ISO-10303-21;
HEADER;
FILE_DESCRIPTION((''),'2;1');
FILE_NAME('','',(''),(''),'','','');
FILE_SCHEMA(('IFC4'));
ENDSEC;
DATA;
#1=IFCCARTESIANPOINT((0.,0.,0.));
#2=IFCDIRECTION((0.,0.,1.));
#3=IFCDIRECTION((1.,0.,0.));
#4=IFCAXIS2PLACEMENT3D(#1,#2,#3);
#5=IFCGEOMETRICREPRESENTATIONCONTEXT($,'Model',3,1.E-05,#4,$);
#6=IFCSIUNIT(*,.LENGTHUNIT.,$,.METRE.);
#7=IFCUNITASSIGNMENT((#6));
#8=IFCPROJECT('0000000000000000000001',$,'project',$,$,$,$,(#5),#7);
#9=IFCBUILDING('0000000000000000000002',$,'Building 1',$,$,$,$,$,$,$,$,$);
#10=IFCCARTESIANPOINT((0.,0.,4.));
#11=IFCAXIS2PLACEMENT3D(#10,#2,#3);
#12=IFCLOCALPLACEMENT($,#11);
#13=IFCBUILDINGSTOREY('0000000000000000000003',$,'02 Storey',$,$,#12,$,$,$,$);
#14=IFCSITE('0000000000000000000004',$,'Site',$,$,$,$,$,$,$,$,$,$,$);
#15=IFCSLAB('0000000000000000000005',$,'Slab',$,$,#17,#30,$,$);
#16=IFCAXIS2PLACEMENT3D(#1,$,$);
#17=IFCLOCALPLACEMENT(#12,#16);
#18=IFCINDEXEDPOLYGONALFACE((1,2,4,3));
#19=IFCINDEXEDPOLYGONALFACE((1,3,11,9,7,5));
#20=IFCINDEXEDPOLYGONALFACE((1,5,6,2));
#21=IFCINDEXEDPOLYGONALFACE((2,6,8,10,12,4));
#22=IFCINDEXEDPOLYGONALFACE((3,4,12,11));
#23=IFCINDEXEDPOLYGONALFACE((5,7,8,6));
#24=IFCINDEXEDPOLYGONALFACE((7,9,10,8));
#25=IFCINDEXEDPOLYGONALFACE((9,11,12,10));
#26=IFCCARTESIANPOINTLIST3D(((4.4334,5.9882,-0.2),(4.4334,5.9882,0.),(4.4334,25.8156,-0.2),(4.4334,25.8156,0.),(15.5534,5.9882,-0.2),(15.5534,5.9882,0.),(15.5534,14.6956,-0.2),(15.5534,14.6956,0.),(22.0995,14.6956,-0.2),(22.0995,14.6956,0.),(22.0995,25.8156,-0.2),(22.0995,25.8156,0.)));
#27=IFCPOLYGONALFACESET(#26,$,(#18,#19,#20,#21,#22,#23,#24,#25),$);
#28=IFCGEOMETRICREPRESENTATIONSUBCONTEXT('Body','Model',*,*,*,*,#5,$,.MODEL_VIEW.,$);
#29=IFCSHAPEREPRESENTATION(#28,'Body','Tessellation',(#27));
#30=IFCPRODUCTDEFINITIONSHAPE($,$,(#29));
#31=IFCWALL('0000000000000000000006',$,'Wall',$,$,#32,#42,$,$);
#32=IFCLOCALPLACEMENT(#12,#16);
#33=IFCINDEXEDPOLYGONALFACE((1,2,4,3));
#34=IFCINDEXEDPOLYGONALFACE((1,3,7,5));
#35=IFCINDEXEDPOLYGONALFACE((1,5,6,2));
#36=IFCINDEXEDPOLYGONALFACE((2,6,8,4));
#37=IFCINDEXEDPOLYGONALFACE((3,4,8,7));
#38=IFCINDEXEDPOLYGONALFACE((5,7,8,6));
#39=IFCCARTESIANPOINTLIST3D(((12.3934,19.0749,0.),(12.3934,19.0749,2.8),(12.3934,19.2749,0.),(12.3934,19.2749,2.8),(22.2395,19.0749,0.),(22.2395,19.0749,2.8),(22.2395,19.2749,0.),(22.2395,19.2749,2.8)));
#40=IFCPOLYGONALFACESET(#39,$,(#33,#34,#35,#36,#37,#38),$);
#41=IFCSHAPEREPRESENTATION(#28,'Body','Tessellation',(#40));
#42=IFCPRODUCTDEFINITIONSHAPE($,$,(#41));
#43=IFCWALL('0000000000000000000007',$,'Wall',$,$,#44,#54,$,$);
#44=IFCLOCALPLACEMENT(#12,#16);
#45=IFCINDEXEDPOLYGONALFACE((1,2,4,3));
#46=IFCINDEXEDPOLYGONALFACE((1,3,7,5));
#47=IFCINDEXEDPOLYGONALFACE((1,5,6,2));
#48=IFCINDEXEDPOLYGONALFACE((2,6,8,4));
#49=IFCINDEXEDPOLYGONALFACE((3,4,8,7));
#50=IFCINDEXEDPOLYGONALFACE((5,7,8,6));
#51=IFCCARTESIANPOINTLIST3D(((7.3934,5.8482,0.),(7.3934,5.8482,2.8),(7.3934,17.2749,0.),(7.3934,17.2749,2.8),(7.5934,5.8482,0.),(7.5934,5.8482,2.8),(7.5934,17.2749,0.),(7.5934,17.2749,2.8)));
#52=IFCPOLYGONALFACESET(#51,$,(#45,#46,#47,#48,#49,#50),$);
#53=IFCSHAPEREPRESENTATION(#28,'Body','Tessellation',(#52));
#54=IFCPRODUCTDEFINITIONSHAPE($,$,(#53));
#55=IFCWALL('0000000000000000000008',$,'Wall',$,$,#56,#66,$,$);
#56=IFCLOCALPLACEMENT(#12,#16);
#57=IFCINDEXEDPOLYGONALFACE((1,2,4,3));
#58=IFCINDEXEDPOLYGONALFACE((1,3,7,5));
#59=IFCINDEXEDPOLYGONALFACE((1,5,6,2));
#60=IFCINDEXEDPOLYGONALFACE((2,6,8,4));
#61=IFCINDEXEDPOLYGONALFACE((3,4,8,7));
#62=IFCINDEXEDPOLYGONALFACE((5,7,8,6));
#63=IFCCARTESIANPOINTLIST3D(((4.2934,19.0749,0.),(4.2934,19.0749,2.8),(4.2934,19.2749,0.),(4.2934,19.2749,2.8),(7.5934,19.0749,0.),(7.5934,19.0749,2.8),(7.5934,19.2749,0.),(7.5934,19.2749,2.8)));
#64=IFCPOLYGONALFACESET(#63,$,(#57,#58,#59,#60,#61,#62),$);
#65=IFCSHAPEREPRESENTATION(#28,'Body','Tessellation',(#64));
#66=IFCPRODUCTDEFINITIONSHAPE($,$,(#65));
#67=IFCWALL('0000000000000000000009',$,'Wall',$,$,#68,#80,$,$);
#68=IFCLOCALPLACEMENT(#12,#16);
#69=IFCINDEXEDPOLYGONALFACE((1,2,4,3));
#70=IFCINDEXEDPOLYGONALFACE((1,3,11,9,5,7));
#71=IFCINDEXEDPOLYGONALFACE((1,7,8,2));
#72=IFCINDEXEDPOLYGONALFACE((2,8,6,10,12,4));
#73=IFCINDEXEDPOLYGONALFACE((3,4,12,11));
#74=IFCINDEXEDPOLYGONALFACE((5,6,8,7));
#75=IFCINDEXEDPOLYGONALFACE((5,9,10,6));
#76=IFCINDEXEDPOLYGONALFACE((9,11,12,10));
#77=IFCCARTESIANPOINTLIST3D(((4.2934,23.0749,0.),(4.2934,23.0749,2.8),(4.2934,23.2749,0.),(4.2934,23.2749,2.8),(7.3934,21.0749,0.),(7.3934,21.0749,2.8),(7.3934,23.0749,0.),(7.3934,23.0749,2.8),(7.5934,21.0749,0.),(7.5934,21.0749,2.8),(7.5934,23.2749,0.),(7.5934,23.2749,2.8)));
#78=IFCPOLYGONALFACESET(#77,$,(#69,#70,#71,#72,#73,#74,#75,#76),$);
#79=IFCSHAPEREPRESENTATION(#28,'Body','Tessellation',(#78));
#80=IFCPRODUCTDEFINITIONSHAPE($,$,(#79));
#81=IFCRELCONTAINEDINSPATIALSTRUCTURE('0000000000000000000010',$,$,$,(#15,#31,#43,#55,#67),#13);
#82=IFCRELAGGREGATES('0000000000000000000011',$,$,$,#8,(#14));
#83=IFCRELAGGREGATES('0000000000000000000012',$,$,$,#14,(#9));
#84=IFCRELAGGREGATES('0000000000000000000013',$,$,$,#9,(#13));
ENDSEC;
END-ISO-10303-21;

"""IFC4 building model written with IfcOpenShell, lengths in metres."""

from ifc_helpers import new_model, si_unit, frame, origin_with_axes, place, context, subcontext, project, spatial, line, indexed_curve, outline, extrude, element, save


model = new_model("IFC4")

# Units and contexts
model_context = context("Model", 3, precision=1e-05, world=origin_with_axes())
body_context = subcontext(model_context, "Body", "Model", "MODEL_VIEW")
ifc_project = project(units=[si_unit("LENGTHUNIT", "METRE")], contexts=[model_context])

# Site, building, storey
site = spatial("IfcSite", under=ifc_project, Name="Site")
building = spatial("IfcBuilding", under=site, Name="Building 1")
storey_placement = place(None, frame((0.0, 0.0, 4.0), z_axis=(0.0, 0.0, 1.0), x_axis=(1.0, 0.0, 0.0)))
storey = spatial("IfcBuildingStorey", under=building, at=storey_placement, Name="02 Storey")

# Slab
slab_placement = place(storey_placement, origin_with_axes())
element("IfcSlab", 1, at=slab_placement, inside=storey, Name="Slab", context=body_context, shape_type="SweptSolid", body=[
    extrude(outline(indexed_curve([(15.5534, 14.6956), (22.0995, 14.6956), (22.0995, 25.8156), (4.4334, 25.8156), (4.4334, 5.9882), (15.5534, 5.9882)], segments=[line(1, 2), line(2, 3), line(3, 4), line(4, 5), line(5, 6)])), origin_with_axes(), (0.0, 0.0, -1.0), 0.2),
])

# Walls
wall_1_placement = place(storey_placement, origin_with_axes())
element("IfcWall", 2, at=wall_1_placement, inside=storey, Name="Wall", context=body_context, shape_type="SweptSolid", body=[
    extrude(outline(indexed_curve([(22.2395, 19.2749), (12.3934, 19.2749), (12.3934, 19.0749), (22.2395, 19.0749)], segments=[line(1, 2), line(2, 3), line(3, 4)])), origin_with_axes(), (0.0, 0.0, 1.0), 2.8),
])
wall_2_placement = place(storey_placement, origin_with_axes())
element("IfcWall", 3, at=wall_2_placement, inside=storey, Name="Wall", context=body_context, shape_type="SweptSolid", body=[
    extrude(outline(indexed_curve([(7.5934, 17.2749), (7.3934, 17.2749), (7.3934, 5.8482), (7.5934, 5.8482)], segments=[line(1, 2), line(2, 3), line(3, 4)])), origin_with_axes(), (0.0, 0.0, 1.0), 2.8),
])
wall_3_placement = place(storey_placement, origin_with_axes())
element("IfcWall", 4, at=wall_3_placement, inside=storey, Name="Wall", context=body_context, shape_type="SweptSolid", body=[
    extrude(outline(indexed_curve([(7.5934, 19.2749), (4.2934, 19.2749), (4.2934, 19.0749), (7.5934, 19.0749)], segments=[line(1, 2), line(2, 3), line(3, 4)])), origin_with_axes(), (0.0, 0.0, 1.0), 2.8),
])
wall_4_placement = place(storey_placement, origin_with_axes())
element("IfcWall", 5, at=wall_4_placement, inside=storey, Name="Wall", context=body_context, shape_type="SweptSolid", body=[
    extrude(outline(indexed_curve([(7.5934, 23.2749), (4.2934, 23.2749), (4.2934, 23.0749), (7.3934, 23.0749), (7.3934, 21.0749), (7.5934, 21.0749)], segments=[line(1, 2), line(2, 3), line(3, 4), line(4, 5), line(5, 6)])), origin_with_axes(), (0.0, 0.0, 1.0), 2.8),
])

save(model, "model.ifc")
